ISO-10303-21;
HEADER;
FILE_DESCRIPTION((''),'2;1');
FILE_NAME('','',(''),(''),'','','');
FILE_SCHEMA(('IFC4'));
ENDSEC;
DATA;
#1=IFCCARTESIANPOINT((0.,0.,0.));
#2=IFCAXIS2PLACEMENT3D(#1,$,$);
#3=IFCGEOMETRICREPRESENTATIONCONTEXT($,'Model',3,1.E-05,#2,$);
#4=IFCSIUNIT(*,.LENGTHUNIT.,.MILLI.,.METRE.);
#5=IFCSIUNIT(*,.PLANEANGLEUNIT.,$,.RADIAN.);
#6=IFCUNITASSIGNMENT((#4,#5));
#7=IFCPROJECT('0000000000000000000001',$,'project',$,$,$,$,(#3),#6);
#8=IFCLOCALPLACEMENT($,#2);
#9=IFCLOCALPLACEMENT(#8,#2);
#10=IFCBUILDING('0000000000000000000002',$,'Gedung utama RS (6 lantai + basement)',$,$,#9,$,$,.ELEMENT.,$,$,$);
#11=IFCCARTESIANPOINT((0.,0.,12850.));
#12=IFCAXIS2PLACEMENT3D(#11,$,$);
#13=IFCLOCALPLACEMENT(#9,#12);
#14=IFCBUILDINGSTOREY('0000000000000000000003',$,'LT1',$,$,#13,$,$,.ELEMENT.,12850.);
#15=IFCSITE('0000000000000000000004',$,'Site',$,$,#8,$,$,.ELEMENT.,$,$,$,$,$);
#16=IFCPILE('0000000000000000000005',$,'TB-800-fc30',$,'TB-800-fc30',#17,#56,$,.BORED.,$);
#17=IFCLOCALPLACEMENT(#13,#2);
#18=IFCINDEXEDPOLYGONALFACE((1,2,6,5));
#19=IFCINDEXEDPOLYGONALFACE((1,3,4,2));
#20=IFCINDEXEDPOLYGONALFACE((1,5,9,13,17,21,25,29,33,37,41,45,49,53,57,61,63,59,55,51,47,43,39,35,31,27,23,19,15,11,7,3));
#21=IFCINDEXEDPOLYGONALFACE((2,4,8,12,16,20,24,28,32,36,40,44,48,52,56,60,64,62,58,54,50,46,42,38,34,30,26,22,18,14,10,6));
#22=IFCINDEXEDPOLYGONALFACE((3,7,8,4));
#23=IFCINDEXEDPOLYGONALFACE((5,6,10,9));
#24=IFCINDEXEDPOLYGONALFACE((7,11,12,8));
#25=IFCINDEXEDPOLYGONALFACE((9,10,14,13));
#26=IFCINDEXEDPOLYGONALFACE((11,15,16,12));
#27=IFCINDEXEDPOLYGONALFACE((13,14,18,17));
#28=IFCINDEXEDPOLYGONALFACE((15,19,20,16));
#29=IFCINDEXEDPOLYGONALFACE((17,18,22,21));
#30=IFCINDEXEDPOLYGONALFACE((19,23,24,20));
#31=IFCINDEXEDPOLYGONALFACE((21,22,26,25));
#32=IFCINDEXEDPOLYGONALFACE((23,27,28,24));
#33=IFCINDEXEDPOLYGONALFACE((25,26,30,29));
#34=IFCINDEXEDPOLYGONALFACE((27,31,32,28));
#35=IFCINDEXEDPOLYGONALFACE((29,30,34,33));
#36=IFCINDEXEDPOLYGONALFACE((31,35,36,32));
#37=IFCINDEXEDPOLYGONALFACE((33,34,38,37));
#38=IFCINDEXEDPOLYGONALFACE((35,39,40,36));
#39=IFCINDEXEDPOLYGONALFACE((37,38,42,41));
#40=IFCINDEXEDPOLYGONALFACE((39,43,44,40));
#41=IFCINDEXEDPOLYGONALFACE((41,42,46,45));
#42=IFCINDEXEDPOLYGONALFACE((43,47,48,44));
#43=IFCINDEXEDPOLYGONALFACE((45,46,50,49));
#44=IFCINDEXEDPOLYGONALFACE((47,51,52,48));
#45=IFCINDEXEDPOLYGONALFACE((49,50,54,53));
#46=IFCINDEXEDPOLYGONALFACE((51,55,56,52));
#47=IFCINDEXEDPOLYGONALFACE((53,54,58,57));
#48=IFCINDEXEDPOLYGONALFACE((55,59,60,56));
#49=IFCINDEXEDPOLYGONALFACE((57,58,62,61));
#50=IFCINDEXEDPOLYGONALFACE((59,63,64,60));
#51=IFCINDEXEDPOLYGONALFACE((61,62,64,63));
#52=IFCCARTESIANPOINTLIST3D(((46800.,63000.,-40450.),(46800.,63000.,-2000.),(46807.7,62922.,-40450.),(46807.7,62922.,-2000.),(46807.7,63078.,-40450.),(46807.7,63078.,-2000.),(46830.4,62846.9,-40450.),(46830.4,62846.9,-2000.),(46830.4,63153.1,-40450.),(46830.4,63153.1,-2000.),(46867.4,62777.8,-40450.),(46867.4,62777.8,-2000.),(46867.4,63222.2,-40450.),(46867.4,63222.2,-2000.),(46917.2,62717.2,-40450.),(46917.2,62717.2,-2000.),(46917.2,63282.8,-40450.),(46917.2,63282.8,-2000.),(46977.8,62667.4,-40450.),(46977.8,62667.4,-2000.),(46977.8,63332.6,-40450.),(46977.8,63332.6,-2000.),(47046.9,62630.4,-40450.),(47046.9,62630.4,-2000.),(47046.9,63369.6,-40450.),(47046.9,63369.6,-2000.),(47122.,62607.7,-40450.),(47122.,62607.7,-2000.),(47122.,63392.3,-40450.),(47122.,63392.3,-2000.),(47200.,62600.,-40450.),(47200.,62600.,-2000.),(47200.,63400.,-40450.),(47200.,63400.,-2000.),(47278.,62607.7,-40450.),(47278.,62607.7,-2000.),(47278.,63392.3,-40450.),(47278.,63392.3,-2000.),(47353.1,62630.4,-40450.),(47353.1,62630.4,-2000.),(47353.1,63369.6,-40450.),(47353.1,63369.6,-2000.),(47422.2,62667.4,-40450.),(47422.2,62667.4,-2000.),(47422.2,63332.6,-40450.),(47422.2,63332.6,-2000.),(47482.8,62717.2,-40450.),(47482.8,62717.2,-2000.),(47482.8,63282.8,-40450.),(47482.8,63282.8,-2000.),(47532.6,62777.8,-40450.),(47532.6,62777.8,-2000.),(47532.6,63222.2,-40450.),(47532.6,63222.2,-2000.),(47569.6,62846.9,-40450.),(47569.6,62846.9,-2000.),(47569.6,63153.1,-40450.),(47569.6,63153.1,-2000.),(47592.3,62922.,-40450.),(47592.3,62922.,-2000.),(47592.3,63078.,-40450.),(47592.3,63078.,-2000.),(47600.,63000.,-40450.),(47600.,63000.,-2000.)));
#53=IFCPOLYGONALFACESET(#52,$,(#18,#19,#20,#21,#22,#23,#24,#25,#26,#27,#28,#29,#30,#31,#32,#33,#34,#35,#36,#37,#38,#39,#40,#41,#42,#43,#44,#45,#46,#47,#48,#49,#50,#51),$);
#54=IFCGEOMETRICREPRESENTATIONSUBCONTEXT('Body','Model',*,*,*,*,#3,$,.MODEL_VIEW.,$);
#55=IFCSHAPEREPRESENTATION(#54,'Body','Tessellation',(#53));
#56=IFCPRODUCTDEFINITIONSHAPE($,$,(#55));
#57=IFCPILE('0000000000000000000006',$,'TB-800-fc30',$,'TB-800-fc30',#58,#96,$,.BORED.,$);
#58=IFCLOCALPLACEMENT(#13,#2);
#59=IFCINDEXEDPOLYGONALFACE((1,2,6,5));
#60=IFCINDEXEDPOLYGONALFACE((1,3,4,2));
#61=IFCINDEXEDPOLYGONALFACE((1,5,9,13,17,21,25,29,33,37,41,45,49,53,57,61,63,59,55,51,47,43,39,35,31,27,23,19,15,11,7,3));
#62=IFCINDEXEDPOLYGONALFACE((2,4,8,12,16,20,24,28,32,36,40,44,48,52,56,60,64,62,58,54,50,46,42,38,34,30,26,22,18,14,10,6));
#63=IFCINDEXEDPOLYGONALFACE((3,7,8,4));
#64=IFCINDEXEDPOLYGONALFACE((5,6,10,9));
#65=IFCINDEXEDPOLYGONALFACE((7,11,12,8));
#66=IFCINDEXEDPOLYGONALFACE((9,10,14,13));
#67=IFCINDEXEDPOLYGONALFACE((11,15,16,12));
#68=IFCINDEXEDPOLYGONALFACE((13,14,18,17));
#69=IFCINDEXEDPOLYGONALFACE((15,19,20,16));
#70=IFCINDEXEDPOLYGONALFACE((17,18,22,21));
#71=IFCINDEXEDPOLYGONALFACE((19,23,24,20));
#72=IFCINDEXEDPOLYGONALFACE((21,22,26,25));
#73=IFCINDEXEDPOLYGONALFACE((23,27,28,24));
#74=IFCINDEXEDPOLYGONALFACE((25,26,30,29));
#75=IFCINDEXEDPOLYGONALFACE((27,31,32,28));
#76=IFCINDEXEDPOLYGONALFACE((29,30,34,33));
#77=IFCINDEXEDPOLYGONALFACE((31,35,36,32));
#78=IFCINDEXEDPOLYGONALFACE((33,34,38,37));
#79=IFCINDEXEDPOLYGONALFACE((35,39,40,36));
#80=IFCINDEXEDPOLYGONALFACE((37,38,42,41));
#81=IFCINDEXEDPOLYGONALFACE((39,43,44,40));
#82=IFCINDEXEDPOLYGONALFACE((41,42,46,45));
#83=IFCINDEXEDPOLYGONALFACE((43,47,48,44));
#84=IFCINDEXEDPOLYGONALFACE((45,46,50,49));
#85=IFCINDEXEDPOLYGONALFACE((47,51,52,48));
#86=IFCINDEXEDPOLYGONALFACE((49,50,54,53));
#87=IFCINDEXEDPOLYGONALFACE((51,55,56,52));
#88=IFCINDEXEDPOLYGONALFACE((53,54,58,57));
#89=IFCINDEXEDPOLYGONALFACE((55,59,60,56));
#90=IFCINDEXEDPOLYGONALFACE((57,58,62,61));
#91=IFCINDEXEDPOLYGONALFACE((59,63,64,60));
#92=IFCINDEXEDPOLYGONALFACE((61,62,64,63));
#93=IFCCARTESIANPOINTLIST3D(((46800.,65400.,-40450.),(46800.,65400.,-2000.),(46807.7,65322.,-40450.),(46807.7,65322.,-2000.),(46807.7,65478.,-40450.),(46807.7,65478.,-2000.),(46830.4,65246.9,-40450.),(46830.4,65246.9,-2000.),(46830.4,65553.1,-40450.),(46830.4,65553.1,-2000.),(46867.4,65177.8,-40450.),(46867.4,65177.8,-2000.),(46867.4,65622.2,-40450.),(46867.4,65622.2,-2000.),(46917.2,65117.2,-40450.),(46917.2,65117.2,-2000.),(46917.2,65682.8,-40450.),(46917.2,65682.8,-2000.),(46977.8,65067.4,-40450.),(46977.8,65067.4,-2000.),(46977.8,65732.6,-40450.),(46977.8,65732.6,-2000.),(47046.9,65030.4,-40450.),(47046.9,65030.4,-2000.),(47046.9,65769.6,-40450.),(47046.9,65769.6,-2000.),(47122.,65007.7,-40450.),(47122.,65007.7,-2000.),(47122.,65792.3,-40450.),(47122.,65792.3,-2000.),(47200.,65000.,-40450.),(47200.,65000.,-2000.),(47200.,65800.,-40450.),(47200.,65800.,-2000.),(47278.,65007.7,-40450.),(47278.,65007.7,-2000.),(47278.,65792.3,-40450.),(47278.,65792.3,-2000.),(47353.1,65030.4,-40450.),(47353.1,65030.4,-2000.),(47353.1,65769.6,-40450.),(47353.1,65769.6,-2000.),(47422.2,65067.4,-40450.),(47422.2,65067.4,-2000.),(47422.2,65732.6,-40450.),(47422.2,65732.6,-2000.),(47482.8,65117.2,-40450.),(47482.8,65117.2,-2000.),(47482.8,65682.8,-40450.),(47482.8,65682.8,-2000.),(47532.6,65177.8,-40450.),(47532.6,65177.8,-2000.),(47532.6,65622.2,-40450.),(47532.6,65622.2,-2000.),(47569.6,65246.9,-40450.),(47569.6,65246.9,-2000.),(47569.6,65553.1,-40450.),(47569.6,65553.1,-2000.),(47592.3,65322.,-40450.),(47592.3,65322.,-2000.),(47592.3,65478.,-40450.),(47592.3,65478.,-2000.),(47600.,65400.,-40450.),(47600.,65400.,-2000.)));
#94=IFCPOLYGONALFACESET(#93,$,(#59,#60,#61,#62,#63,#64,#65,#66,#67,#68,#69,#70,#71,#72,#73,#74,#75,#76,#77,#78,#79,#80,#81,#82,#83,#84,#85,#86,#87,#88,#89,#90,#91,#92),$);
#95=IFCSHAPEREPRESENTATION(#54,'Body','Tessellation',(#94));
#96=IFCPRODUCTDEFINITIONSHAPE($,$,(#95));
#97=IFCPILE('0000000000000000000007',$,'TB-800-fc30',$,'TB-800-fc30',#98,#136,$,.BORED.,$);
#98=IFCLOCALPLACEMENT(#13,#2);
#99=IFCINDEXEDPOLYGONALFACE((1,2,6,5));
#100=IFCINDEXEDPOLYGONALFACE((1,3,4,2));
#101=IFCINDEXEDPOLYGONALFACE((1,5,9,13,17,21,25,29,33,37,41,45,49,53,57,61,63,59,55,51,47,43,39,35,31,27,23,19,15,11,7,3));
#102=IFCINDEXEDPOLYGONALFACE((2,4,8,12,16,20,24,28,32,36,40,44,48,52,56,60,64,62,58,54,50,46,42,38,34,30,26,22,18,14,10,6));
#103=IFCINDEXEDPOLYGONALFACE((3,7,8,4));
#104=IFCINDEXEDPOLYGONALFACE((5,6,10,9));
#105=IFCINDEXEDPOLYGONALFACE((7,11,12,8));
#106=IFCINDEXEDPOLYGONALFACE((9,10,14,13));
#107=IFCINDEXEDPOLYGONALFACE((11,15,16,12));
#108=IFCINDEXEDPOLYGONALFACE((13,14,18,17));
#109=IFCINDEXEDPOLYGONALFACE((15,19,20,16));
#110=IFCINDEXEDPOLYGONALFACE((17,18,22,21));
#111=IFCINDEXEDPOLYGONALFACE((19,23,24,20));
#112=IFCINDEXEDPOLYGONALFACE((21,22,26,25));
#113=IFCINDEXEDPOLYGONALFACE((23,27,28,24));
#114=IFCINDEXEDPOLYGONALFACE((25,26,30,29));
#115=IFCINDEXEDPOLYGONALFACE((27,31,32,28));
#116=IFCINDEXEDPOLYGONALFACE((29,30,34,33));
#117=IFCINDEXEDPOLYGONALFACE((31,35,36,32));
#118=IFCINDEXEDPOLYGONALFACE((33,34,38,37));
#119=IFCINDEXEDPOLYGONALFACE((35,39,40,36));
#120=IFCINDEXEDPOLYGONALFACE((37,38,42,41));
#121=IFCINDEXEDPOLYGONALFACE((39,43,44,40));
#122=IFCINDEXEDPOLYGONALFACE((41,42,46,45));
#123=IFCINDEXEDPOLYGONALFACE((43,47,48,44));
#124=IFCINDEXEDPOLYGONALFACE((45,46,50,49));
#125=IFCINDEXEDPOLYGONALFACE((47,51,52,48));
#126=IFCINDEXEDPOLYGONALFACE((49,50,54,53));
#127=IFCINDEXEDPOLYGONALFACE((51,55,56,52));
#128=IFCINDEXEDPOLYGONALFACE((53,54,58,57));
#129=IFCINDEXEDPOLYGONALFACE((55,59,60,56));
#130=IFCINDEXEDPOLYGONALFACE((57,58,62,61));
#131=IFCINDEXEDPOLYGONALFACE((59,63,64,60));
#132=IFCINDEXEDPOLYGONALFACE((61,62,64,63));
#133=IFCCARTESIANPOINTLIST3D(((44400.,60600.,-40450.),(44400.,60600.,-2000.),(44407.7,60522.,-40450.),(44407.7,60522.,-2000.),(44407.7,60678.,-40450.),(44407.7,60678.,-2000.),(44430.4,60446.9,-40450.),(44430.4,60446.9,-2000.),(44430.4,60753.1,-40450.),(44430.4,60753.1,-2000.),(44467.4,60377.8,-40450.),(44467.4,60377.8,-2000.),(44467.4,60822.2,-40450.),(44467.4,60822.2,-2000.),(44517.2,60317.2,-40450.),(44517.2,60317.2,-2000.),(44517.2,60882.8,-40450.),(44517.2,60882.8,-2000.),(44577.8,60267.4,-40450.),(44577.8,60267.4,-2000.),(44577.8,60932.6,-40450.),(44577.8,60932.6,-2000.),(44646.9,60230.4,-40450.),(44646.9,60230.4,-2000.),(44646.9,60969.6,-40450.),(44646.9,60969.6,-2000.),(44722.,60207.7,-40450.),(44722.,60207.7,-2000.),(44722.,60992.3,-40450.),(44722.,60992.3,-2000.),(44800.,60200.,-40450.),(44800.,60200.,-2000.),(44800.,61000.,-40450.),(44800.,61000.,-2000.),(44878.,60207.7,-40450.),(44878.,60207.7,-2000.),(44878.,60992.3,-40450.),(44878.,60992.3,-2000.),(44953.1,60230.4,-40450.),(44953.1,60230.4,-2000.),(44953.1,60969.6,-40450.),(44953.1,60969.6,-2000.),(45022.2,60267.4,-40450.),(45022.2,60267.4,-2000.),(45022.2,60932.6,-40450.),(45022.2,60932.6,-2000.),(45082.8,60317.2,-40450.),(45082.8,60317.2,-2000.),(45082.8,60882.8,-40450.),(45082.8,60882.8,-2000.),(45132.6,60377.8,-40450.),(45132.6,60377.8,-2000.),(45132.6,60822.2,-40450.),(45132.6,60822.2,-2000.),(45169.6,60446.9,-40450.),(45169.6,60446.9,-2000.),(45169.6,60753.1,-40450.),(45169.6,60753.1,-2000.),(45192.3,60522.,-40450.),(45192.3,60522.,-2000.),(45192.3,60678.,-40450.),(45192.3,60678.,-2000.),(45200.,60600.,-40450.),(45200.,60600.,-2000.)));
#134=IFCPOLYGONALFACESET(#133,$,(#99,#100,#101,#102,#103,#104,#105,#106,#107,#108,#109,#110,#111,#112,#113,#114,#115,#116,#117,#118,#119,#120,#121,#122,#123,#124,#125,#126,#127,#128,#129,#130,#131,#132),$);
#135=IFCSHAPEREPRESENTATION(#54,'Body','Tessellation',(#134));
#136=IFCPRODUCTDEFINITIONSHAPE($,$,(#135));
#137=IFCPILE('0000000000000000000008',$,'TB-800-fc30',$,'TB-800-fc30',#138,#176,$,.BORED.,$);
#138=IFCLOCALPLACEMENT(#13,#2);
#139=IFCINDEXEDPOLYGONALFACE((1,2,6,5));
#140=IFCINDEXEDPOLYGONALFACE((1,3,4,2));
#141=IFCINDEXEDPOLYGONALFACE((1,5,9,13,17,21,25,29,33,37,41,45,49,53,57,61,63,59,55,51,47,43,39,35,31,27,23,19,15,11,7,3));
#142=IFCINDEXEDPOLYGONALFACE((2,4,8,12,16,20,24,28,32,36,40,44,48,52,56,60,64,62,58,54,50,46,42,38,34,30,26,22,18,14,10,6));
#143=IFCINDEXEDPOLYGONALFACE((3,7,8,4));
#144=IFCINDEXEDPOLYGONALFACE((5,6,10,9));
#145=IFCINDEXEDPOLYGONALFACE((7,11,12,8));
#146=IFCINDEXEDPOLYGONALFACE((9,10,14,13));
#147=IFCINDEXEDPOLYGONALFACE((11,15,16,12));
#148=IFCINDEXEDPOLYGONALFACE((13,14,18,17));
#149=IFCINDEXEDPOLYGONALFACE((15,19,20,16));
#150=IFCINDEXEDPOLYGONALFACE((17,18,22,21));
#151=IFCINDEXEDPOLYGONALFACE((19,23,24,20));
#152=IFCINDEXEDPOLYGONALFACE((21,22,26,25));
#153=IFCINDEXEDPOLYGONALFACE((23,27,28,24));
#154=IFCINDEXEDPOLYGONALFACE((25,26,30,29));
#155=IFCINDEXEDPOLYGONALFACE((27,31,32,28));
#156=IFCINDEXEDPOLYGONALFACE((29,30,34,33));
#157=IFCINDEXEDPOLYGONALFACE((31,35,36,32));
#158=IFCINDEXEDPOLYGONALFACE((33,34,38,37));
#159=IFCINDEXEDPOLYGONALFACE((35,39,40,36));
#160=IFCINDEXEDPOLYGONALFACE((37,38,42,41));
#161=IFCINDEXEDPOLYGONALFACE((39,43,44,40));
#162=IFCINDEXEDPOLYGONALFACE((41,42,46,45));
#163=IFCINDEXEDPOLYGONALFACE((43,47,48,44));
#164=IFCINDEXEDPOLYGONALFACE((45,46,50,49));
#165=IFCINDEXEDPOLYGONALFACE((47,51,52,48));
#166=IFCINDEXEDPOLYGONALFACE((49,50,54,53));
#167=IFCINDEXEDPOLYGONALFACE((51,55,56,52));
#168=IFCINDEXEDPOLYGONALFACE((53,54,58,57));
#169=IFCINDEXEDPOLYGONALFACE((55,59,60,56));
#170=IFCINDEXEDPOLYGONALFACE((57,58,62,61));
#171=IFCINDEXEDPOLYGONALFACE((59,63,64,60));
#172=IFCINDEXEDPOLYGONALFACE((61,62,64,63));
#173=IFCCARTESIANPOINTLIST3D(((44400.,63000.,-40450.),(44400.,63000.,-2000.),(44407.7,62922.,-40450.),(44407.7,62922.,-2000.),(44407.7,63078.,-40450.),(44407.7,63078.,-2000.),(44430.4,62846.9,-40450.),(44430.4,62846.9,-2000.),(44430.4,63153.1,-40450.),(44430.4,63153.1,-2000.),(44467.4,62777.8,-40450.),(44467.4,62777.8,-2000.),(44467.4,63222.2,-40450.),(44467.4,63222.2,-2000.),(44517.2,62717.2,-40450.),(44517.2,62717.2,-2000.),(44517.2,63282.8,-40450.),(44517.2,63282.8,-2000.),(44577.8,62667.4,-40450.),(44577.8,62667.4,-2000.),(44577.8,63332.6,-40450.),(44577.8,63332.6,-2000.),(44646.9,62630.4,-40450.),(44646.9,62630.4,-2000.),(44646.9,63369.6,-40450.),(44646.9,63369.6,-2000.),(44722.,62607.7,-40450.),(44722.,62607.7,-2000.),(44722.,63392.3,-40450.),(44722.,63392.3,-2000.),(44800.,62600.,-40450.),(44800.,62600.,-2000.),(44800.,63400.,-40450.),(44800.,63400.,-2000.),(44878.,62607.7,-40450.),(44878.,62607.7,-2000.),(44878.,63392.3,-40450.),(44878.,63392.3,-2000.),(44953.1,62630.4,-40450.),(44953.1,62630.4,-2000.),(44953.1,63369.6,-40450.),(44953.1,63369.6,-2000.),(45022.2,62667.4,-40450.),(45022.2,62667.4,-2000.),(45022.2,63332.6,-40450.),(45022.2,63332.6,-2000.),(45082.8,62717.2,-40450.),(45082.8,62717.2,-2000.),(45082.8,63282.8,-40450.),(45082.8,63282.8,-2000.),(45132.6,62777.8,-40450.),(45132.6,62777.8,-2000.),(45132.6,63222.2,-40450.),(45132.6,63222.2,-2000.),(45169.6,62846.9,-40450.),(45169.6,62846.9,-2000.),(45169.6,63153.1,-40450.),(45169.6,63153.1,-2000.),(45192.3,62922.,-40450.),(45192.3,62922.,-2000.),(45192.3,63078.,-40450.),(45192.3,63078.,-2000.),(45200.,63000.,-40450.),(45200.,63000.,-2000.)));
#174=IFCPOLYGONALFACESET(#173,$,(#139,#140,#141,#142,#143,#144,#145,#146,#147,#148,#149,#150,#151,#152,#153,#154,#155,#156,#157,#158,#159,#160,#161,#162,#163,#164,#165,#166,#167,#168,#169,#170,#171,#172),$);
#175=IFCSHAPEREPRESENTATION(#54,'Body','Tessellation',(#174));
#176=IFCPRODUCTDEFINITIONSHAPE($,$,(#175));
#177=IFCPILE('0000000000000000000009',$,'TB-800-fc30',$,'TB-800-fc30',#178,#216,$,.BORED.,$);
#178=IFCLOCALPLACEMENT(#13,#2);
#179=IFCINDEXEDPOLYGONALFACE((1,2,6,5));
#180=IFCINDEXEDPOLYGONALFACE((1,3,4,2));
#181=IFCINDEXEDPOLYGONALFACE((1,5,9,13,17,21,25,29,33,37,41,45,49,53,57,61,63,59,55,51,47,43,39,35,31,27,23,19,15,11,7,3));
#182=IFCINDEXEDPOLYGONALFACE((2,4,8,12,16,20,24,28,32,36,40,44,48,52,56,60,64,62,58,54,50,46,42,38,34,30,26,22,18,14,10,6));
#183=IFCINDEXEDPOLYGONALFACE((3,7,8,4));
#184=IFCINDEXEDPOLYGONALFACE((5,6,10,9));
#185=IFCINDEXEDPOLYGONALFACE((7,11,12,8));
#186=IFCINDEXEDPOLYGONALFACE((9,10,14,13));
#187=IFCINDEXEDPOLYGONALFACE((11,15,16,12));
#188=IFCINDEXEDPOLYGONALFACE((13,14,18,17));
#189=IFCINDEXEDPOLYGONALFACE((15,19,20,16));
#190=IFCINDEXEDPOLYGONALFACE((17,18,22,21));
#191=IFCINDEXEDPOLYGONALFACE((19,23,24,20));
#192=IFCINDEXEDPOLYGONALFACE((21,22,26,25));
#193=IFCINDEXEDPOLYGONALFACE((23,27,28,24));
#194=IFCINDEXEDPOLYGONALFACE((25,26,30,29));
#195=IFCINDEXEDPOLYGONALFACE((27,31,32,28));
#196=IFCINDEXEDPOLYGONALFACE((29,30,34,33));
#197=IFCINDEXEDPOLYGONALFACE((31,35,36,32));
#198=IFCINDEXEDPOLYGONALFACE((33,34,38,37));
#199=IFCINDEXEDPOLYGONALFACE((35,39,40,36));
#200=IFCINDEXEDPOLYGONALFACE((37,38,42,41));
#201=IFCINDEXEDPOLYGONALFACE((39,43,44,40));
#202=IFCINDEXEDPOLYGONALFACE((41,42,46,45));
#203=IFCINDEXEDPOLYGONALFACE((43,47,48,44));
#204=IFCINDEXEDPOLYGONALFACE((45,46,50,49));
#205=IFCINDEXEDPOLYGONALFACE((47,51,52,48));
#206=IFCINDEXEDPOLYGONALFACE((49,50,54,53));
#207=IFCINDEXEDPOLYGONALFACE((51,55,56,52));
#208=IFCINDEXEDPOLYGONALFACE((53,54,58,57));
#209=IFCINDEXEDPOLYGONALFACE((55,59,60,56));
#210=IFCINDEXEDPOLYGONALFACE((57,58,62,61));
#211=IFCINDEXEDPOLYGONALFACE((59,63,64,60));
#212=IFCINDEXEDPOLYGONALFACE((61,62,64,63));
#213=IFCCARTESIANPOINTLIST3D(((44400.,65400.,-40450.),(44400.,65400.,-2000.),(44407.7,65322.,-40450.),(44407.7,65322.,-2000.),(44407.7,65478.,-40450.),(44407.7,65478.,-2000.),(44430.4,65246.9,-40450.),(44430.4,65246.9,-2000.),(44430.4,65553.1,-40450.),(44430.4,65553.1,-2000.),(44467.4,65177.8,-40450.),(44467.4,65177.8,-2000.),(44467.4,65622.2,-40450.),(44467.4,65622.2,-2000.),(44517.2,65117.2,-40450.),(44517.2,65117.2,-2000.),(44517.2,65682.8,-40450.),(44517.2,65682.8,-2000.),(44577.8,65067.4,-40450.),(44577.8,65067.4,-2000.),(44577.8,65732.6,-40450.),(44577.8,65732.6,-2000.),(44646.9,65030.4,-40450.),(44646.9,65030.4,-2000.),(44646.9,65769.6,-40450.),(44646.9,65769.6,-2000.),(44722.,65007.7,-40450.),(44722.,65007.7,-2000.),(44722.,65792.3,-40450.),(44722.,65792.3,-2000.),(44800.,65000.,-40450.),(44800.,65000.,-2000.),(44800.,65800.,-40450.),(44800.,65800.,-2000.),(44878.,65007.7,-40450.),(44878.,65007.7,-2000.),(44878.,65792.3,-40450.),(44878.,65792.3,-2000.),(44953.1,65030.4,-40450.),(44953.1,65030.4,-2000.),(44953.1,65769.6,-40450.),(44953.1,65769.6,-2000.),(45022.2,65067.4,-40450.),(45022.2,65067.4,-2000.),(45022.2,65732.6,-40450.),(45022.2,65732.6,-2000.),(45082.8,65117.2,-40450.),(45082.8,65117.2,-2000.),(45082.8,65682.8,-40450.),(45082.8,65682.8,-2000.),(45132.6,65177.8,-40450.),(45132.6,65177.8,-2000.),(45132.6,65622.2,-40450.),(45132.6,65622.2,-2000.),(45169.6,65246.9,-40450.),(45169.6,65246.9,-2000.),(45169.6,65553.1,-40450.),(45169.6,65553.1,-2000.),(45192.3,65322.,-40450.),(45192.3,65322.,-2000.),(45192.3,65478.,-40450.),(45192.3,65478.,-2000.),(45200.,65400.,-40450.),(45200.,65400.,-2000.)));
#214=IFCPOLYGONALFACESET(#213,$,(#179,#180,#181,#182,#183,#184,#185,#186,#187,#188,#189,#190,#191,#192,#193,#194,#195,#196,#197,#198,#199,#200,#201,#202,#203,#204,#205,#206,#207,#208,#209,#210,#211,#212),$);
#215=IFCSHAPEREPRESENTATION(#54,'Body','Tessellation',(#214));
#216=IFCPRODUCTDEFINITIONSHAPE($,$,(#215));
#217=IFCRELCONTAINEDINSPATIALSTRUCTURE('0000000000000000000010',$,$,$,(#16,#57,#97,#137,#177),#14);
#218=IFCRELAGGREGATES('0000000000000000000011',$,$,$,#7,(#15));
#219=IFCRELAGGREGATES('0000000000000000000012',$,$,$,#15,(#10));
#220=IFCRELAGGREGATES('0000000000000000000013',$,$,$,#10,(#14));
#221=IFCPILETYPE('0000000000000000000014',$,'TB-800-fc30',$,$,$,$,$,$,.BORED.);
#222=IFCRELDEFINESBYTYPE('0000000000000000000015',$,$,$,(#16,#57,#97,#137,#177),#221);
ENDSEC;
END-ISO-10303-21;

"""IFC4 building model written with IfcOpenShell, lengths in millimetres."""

from ifc_helpers import new_model, si_unit, frame, origin, origin_2d, place, context, subcontext, project, spatial, circle, extrude, material_profile, profile_set, profile_usage, type_object, element, save


model = new_model("IFC4")

# Units and contexts
model_context = context("Model", 3, precision=1e-05, world=origin())
body_context = subcontext(model_context, "Body", "Model", "MODEL_VIEW")
ifc_project = project(units=[si_unit("LENGTHUNIT", "METRE", prefix="MILLI"), si_unit("PLANEANGLEUNIT", "RADIAN")], contexts=[model_context])

# Site, building, storey
site_placement = place(None, origin())
site = spatial("IfcSite", under=ifc_project, at=site_placement, Name="Site", CompositionType="ELEMENT")
building_placement = place(site_placement, origin())
building = spatial("IfcBuilding", under=site, at=building_placement, Name="Gedung utama RS (6 lantai + basement)", CompositionType="ELEMENT")
storey_placement = place(building_placement, frame((0.0, 0.0, 12850.0)))
storey = spatial("IfcBuildingStorey", under=building, at=storey_placement, Name="LT1", CompositionType="ELEMENT", Elevation=12850.0)

# Piles
ifc_material_profile = material_profile(None, circle(Radius=400.0, at=origin_2d()), Name="TB-800-fc30")
ifc_profile_set = profile_set([ifc_material_profile], Name="TB-800-fc30")
ifc_profile_usage = profile_usage(ifc_profile_set, cardinal=5)
pile_type = type_object("IfcPileType", Name="TB-800-fc30", PredefinedType="BORED", material=ifc_profile_set)
for number, where, z_axis, x_axis, name in (
    (1, (47200.0, 63000.0, -40450.0), (0.0, 0.0, 1.0), (1.0, 0.0, 0.0), "TB-800-fc30"),
    (2, (47200.0, 65400.0, -40450.0), (0.0, 0.0, 1.0), (1.0, 0.0, 0.0), "TB-800-fc30"),
    (3, (44800.0, 60600.0, -40450.0), (0.0, 0.0, 1.0), (1.0, 0.0, 0.0), "TB-800-fc30"),
    (4, (44800.0, 63000.0, -40450.0), (0.0, 0.0, 1.0), (1.0, 0.0, 0.0), "TB-800-fc30"),
    (5, (44800.0, 65400.0, -40450.0), (0.0, 0.0, 1.0), (1.0, 0.0, 0.0), "TB-800-fc30"),
):
    element("IfcPile", number, at=place(storey_placement, frame(where, z_axis=z_axis, x_axis=x_axis)), inside=storey, type_object=pile_type, material=ifc_profile_usage, Name=name, ObjectType="TB-800-fc30", PredefinedType="BORED", context=body_context, shape_type="SweptSolid", body=[
        extrude(circle(Radius=400.0, at=origin_2d()), origin(), (0.0, 0.0, 1.0), 38450.0),
    ])

save(model, "model.ifc")
